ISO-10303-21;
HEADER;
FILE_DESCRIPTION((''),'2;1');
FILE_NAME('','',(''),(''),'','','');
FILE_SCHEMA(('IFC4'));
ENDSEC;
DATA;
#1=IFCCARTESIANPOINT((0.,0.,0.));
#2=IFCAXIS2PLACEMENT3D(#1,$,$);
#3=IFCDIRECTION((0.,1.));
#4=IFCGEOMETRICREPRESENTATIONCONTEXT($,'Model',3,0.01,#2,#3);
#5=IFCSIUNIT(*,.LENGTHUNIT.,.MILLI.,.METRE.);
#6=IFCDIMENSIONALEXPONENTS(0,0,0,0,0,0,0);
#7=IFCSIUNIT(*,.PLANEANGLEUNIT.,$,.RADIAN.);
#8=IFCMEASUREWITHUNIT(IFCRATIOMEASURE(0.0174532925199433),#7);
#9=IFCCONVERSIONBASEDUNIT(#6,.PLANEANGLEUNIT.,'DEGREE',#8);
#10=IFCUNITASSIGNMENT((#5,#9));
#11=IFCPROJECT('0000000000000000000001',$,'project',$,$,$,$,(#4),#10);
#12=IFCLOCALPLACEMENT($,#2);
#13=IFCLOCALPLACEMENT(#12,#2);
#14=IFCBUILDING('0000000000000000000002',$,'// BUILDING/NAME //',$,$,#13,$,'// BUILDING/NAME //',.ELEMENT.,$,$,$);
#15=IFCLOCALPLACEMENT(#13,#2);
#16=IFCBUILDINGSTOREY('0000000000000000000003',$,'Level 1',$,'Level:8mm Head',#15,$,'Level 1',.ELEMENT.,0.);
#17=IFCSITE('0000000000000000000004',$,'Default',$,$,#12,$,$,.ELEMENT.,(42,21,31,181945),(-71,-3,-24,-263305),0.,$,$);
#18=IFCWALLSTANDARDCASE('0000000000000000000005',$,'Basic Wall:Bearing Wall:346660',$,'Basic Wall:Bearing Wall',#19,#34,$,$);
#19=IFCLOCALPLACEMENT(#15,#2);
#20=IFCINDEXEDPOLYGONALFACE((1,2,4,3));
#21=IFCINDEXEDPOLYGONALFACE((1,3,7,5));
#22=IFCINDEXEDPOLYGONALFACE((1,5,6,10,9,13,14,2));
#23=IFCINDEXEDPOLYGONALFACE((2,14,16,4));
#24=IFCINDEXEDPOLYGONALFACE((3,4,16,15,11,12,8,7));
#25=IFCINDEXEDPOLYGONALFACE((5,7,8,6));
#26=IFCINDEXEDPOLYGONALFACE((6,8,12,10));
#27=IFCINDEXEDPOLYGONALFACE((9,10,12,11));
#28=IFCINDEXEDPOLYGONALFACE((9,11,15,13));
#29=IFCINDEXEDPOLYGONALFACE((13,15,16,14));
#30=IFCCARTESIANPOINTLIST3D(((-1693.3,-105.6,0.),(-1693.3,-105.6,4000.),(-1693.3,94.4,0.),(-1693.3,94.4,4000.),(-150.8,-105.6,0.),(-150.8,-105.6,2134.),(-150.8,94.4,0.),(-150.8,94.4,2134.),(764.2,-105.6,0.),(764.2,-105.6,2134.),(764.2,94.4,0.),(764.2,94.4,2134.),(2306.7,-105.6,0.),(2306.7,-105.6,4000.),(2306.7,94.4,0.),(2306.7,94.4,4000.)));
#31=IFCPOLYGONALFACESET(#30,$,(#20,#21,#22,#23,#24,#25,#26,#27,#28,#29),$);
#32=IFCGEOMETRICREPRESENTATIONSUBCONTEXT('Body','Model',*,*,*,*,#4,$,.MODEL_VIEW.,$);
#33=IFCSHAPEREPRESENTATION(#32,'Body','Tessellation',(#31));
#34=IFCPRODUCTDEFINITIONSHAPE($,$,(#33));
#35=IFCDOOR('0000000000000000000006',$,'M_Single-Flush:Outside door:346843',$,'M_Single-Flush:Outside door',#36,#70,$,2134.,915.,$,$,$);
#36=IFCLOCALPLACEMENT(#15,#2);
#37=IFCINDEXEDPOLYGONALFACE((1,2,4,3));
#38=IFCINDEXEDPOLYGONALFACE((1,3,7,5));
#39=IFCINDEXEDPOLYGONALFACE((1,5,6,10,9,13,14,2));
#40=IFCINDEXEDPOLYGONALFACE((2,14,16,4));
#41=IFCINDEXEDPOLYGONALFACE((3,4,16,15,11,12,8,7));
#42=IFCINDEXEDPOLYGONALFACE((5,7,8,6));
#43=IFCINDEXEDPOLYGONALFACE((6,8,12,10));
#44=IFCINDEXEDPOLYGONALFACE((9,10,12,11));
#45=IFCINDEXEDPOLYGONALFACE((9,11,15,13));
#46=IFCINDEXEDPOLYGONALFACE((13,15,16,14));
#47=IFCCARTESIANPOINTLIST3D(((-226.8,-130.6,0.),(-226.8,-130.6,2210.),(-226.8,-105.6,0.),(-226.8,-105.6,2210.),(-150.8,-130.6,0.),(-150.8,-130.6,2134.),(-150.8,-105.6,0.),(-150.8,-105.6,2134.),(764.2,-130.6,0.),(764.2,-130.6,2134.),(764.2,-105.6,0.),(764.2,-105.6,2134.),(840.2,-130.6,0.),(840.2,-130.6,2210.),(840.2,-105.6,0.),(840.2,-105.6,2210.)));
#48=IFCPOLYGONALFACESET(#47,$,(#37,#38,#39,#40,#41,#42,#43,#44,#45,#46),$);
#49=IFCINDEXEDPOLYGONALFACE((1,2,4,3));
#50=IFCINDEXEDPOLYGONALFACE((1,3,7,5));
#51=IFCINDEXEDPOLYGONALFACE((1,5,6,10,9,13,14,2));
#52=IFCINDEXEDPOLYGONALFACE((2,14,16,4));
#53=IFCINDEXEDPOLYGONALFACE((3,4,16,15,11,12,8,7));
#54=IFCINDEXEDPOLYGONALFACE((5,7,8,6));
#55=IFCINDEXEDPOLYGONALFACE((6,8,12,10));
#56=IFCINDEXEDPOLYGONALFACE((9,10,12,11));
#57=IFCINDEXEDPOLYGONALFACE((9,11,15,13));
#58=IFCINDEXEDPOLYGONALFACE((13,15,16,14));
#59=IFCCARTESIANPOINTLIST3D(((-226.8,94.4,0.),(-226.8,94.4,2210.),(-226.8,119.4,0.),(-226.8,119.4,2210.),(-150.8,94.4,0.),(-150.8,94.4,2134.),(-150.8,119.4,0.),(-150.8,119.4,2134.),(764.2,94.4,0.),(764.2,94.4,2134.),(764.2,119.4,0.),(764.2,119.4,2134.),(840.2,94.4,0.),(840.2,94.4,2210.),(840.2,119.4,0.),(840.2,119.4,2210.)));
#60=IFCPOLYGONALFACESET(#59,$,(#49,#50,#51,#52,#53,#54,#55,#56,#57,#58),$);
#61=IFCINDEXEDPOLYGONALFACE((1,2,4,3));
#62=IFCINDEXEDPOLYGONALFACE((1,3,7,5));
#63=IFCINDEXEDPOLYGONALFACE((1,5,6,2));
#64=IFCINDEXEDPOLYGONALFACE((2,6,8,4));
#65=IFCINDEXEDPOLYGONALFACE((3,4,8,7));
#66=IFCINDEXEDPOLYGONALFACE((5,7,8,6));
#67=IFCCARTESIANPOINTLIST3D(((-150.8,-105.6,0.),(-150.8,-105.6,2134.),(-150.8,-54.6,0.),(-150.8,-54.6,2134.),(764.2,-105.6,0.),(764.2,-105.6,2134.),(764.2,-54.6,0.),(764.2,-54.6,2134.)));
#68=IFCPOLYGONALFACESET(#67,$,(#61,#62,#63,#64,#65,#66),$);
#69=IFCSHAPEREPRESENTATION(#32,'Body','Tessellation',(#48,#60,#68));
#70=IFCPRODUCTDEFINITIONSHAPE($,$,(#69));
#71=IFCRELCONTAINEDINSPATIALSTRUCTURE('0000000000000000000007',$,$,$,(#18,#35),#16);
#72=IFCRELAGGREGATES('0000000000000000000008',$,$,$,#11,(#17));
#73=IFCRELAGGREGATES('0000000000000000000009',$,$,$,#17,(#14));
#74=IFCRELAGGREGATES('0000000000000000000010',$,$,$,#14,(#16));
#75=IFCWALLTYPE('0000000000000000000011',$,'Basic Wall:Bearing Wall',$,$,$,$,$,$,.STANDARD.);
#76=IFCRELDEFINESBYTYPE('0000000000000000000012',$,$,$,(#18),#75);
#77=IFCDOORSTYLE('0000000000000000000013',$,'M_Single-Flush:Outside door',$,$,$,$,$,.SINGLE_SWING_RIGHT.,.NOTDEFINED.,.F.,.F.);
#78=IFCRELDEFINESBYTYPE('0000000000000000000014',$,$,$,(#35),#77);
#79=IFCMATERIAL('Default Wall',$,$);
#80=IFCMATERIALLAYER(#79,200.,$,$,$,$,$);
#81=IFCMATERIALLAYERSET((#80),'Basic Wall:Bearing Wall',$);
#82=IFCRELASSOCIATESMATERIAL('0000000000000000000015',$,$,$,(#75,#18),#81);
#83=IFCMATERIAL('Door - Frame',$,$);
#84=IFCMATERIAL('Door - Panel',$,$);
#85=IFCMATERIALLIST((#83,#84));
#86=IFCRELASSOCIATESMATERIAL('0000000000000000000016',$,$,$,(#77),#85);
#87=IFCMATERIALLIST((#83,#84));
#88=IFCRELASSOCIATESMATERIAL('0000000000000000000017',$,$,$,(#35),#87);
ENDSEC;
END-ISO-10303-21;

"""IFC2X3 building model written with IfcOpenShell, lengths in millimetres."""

from ifc_helpers import new_model, entity, si_unit, converted_unit, direction, frame, frame_2d, origin, place, context, subcontext, project, spatial, polyline, rectangle, outline, extrude, source, transform, mapped, material, material_list, layer, layer_set, layer_usage, type_object, type_shapes, element, fill, save


model = new_model("IFC2X3")

# Units and contexts
model_context = context("Model", 3, precision=0.01, world=origin(), true_north=direction((0.0, 1.0)))
body_context = subcontext(model_context, "Body", "Model", "MODEL_VIEW")
ifc_project = project(units=[si_unit("LENGTHUNIT", "METRE", prefix="MILLI"), converted_unit("PLANEANGLEUNIT", "DEGREE", entity("IfcRatioMeasure", 0.0174532925199433), si_unit("PLANEANGLEUNIT", "RADIAN"), dimensions=[0, 0, 0, 0, 0, 0, 0])], contexts=[model_context])

# Site, building, storey
site_placement = place(None, origin())
site = spatial("IfcSite", under=ifc_project, at=site_placement, Name="Default", CompositionType="ELEMENT", RefLatitude=(42, 21, 31, 181945), RefLongitude=(-71, -3, -24, -263305), RefElevation=0.0)
building_placement = place(site_placement, origin())
building = spatial("IfcBuilding", under=site, at=building_placement, Name="// BUILDING/NAME //", LongName="// BUILDING/NAME //", CompositionType="ELEMENT")
storey_placement = place(building_placement, origin())
storey = spatial("IfcBuildingStorey", under=building, at=storey_placement, Name="Level 1", ObjectType="Level:8mm Head", LongName="Level 1", CompositionType="ELEMENT", Elevation=0.0)

# Wall, opening, door
ifc_material_1 = material(Name="Default Wall")
ifc_layer = layer(ifc_material_1, 200.0)
ifc_layer_set = layer_set([ifc_layer], Name="Basic Wall:Bearing Wall")
ifc_layer_usage = layer_usage(ifc_layer_set, "AXIS2", "NEGATIVE", 100.0)
wall_type = type_object("IfcWallType", Name="Basic Wall:Bearing Wall", PredefinedType="STANDARD", material=ifc_layer_set)
wall_placement = place(storey_placement, frame((-1693.3, -5.6, 0.0)))
wall = element("IfcWallStandardCase", 1, at=wall_placement, inside=storey, type_object=wall_type, material=ifc_layer_usage, Name="Basic Wall:Bearing Wall:346660", ObjectType="Basic Wall:Bearing Wall", context=body_context, shape_type="SweptSolid", body=[
    extrude(rectangle(XDim=4000.0, YDim=200.0, at=frame_2d((2000.0, 0.0), x_axis=(-1.0, 0.0))), origin(), (0.0, 0.0, 1.0), 4000.0),
])
opening_placement = place(wall_placement, frame((2457.5, 100.0, 0.0)))
opening = element("IfcOpeningElement", 2, at=opening_placement, cuts=wall, ObjectType="Opening", context=body_context, shape_type="SweptSolid", body=[
    extrude(rectangle(XDim=915.0, YDim=2134.0, at=frame_2d((1067.0, 457.5), x_axis=(0.0, 1.0))), frame((0.0, 0.0, 0.0), z_axis=(0.0, -1.0, 0.0), x_axis=(0.0, 0.0, 1.0)), (0.0, 0.0, 1.0), 200.0),
])
ifc_material_2 = material(Name="Door - Frame")
ifc_material_3 = material(Name="Door - Panel")
ifc_material_list_1 = material_list([ifc_material_2, ifc_material_3])
ifc_material_list_2 = material_list([ifc_material_2, ifc_material_3])
door_style = type_object("IfcDoorStyle", Name="M_Single-Flush:Outside door", ConstructionType="NOTDEFINED", OperationType="SINGLE_SWING_RIGHT", ParameterTakesPrecedence=False, Sizeable=False, material=ifc_material_list_2)
shared_shape = source(origin(), body_context, "Body", "SweptSolid", [
    extrude(outline(polyline([(-533.5, -1124.0), (533.5, -1124.0), (533.5, 1086.0), (457.5, 1086.0), (457.5, -1048.0), (-457.5, -1048.0), (-457.5, 1086.0), (-533.5, 1086.0), (-533.5, -1124.0)])), frame((457.5, 200.0, 1086.0), z_axis=(0.0, 1.0, 0.0), x_axis=(1.0, 0.0, 0.0)), (0.0, 0.0, 1.0), 25.0),
    extrude(outline(polyline([(-1124.0, -533.5), (1086.0, -533.5), (1086.0, -457.5), (-1048.0, -457.5), (-1048.0, 457.5), (1086.0, 457.5), (1086.0, 533.5), (-1124.0, 533.5), (-1124.0, -533.5)])), frame((457.5, -25.0, 1086.0), z_axis=(0.0, 1.0, 0.0), x_axis=(0.0, 0.0, -1.0)), (0.0, 0.0, 1.0), 25.0),
    extrude(rectangle(XDim=51.0, YDim=915.0, at=frame_2d((0.0, 0.0), x_axis=(1.0, 0.0))), frame((457.5, 174.5, 0.0), z_axis=(0.0, 0.0, 1.0), x_axis=(0.0, 1.0, 0.0)), (0.0, 0.0, 1.0), 2134.0),
])
type_shapes(door_style, [shared_shape])
door_placement = place(opening_placement, frame((0.0, 0.0, 0.0), z_axis=(0.0, 0.0, 1.0), x_axis=(-1.0, 0.0, 0.0)))
door = element("IfcDoor", 3, at=door_placement, inside=storey, type_object=door_style, material=ifc_material_list_1, Name="M_Single-Flush:Outside door:346843", ObjectType="M_Single-Flush:Outside door", OverallHeight=2134.0, OverallWidth=915.0, context=body_context, shape_type="MappedRepresentation", body=[
    mapped(shared_shape, transform((0.0, 0.0, 0.0), scale=1.0)),
])
fill(opening, door)

save(model, "model.ifc")
